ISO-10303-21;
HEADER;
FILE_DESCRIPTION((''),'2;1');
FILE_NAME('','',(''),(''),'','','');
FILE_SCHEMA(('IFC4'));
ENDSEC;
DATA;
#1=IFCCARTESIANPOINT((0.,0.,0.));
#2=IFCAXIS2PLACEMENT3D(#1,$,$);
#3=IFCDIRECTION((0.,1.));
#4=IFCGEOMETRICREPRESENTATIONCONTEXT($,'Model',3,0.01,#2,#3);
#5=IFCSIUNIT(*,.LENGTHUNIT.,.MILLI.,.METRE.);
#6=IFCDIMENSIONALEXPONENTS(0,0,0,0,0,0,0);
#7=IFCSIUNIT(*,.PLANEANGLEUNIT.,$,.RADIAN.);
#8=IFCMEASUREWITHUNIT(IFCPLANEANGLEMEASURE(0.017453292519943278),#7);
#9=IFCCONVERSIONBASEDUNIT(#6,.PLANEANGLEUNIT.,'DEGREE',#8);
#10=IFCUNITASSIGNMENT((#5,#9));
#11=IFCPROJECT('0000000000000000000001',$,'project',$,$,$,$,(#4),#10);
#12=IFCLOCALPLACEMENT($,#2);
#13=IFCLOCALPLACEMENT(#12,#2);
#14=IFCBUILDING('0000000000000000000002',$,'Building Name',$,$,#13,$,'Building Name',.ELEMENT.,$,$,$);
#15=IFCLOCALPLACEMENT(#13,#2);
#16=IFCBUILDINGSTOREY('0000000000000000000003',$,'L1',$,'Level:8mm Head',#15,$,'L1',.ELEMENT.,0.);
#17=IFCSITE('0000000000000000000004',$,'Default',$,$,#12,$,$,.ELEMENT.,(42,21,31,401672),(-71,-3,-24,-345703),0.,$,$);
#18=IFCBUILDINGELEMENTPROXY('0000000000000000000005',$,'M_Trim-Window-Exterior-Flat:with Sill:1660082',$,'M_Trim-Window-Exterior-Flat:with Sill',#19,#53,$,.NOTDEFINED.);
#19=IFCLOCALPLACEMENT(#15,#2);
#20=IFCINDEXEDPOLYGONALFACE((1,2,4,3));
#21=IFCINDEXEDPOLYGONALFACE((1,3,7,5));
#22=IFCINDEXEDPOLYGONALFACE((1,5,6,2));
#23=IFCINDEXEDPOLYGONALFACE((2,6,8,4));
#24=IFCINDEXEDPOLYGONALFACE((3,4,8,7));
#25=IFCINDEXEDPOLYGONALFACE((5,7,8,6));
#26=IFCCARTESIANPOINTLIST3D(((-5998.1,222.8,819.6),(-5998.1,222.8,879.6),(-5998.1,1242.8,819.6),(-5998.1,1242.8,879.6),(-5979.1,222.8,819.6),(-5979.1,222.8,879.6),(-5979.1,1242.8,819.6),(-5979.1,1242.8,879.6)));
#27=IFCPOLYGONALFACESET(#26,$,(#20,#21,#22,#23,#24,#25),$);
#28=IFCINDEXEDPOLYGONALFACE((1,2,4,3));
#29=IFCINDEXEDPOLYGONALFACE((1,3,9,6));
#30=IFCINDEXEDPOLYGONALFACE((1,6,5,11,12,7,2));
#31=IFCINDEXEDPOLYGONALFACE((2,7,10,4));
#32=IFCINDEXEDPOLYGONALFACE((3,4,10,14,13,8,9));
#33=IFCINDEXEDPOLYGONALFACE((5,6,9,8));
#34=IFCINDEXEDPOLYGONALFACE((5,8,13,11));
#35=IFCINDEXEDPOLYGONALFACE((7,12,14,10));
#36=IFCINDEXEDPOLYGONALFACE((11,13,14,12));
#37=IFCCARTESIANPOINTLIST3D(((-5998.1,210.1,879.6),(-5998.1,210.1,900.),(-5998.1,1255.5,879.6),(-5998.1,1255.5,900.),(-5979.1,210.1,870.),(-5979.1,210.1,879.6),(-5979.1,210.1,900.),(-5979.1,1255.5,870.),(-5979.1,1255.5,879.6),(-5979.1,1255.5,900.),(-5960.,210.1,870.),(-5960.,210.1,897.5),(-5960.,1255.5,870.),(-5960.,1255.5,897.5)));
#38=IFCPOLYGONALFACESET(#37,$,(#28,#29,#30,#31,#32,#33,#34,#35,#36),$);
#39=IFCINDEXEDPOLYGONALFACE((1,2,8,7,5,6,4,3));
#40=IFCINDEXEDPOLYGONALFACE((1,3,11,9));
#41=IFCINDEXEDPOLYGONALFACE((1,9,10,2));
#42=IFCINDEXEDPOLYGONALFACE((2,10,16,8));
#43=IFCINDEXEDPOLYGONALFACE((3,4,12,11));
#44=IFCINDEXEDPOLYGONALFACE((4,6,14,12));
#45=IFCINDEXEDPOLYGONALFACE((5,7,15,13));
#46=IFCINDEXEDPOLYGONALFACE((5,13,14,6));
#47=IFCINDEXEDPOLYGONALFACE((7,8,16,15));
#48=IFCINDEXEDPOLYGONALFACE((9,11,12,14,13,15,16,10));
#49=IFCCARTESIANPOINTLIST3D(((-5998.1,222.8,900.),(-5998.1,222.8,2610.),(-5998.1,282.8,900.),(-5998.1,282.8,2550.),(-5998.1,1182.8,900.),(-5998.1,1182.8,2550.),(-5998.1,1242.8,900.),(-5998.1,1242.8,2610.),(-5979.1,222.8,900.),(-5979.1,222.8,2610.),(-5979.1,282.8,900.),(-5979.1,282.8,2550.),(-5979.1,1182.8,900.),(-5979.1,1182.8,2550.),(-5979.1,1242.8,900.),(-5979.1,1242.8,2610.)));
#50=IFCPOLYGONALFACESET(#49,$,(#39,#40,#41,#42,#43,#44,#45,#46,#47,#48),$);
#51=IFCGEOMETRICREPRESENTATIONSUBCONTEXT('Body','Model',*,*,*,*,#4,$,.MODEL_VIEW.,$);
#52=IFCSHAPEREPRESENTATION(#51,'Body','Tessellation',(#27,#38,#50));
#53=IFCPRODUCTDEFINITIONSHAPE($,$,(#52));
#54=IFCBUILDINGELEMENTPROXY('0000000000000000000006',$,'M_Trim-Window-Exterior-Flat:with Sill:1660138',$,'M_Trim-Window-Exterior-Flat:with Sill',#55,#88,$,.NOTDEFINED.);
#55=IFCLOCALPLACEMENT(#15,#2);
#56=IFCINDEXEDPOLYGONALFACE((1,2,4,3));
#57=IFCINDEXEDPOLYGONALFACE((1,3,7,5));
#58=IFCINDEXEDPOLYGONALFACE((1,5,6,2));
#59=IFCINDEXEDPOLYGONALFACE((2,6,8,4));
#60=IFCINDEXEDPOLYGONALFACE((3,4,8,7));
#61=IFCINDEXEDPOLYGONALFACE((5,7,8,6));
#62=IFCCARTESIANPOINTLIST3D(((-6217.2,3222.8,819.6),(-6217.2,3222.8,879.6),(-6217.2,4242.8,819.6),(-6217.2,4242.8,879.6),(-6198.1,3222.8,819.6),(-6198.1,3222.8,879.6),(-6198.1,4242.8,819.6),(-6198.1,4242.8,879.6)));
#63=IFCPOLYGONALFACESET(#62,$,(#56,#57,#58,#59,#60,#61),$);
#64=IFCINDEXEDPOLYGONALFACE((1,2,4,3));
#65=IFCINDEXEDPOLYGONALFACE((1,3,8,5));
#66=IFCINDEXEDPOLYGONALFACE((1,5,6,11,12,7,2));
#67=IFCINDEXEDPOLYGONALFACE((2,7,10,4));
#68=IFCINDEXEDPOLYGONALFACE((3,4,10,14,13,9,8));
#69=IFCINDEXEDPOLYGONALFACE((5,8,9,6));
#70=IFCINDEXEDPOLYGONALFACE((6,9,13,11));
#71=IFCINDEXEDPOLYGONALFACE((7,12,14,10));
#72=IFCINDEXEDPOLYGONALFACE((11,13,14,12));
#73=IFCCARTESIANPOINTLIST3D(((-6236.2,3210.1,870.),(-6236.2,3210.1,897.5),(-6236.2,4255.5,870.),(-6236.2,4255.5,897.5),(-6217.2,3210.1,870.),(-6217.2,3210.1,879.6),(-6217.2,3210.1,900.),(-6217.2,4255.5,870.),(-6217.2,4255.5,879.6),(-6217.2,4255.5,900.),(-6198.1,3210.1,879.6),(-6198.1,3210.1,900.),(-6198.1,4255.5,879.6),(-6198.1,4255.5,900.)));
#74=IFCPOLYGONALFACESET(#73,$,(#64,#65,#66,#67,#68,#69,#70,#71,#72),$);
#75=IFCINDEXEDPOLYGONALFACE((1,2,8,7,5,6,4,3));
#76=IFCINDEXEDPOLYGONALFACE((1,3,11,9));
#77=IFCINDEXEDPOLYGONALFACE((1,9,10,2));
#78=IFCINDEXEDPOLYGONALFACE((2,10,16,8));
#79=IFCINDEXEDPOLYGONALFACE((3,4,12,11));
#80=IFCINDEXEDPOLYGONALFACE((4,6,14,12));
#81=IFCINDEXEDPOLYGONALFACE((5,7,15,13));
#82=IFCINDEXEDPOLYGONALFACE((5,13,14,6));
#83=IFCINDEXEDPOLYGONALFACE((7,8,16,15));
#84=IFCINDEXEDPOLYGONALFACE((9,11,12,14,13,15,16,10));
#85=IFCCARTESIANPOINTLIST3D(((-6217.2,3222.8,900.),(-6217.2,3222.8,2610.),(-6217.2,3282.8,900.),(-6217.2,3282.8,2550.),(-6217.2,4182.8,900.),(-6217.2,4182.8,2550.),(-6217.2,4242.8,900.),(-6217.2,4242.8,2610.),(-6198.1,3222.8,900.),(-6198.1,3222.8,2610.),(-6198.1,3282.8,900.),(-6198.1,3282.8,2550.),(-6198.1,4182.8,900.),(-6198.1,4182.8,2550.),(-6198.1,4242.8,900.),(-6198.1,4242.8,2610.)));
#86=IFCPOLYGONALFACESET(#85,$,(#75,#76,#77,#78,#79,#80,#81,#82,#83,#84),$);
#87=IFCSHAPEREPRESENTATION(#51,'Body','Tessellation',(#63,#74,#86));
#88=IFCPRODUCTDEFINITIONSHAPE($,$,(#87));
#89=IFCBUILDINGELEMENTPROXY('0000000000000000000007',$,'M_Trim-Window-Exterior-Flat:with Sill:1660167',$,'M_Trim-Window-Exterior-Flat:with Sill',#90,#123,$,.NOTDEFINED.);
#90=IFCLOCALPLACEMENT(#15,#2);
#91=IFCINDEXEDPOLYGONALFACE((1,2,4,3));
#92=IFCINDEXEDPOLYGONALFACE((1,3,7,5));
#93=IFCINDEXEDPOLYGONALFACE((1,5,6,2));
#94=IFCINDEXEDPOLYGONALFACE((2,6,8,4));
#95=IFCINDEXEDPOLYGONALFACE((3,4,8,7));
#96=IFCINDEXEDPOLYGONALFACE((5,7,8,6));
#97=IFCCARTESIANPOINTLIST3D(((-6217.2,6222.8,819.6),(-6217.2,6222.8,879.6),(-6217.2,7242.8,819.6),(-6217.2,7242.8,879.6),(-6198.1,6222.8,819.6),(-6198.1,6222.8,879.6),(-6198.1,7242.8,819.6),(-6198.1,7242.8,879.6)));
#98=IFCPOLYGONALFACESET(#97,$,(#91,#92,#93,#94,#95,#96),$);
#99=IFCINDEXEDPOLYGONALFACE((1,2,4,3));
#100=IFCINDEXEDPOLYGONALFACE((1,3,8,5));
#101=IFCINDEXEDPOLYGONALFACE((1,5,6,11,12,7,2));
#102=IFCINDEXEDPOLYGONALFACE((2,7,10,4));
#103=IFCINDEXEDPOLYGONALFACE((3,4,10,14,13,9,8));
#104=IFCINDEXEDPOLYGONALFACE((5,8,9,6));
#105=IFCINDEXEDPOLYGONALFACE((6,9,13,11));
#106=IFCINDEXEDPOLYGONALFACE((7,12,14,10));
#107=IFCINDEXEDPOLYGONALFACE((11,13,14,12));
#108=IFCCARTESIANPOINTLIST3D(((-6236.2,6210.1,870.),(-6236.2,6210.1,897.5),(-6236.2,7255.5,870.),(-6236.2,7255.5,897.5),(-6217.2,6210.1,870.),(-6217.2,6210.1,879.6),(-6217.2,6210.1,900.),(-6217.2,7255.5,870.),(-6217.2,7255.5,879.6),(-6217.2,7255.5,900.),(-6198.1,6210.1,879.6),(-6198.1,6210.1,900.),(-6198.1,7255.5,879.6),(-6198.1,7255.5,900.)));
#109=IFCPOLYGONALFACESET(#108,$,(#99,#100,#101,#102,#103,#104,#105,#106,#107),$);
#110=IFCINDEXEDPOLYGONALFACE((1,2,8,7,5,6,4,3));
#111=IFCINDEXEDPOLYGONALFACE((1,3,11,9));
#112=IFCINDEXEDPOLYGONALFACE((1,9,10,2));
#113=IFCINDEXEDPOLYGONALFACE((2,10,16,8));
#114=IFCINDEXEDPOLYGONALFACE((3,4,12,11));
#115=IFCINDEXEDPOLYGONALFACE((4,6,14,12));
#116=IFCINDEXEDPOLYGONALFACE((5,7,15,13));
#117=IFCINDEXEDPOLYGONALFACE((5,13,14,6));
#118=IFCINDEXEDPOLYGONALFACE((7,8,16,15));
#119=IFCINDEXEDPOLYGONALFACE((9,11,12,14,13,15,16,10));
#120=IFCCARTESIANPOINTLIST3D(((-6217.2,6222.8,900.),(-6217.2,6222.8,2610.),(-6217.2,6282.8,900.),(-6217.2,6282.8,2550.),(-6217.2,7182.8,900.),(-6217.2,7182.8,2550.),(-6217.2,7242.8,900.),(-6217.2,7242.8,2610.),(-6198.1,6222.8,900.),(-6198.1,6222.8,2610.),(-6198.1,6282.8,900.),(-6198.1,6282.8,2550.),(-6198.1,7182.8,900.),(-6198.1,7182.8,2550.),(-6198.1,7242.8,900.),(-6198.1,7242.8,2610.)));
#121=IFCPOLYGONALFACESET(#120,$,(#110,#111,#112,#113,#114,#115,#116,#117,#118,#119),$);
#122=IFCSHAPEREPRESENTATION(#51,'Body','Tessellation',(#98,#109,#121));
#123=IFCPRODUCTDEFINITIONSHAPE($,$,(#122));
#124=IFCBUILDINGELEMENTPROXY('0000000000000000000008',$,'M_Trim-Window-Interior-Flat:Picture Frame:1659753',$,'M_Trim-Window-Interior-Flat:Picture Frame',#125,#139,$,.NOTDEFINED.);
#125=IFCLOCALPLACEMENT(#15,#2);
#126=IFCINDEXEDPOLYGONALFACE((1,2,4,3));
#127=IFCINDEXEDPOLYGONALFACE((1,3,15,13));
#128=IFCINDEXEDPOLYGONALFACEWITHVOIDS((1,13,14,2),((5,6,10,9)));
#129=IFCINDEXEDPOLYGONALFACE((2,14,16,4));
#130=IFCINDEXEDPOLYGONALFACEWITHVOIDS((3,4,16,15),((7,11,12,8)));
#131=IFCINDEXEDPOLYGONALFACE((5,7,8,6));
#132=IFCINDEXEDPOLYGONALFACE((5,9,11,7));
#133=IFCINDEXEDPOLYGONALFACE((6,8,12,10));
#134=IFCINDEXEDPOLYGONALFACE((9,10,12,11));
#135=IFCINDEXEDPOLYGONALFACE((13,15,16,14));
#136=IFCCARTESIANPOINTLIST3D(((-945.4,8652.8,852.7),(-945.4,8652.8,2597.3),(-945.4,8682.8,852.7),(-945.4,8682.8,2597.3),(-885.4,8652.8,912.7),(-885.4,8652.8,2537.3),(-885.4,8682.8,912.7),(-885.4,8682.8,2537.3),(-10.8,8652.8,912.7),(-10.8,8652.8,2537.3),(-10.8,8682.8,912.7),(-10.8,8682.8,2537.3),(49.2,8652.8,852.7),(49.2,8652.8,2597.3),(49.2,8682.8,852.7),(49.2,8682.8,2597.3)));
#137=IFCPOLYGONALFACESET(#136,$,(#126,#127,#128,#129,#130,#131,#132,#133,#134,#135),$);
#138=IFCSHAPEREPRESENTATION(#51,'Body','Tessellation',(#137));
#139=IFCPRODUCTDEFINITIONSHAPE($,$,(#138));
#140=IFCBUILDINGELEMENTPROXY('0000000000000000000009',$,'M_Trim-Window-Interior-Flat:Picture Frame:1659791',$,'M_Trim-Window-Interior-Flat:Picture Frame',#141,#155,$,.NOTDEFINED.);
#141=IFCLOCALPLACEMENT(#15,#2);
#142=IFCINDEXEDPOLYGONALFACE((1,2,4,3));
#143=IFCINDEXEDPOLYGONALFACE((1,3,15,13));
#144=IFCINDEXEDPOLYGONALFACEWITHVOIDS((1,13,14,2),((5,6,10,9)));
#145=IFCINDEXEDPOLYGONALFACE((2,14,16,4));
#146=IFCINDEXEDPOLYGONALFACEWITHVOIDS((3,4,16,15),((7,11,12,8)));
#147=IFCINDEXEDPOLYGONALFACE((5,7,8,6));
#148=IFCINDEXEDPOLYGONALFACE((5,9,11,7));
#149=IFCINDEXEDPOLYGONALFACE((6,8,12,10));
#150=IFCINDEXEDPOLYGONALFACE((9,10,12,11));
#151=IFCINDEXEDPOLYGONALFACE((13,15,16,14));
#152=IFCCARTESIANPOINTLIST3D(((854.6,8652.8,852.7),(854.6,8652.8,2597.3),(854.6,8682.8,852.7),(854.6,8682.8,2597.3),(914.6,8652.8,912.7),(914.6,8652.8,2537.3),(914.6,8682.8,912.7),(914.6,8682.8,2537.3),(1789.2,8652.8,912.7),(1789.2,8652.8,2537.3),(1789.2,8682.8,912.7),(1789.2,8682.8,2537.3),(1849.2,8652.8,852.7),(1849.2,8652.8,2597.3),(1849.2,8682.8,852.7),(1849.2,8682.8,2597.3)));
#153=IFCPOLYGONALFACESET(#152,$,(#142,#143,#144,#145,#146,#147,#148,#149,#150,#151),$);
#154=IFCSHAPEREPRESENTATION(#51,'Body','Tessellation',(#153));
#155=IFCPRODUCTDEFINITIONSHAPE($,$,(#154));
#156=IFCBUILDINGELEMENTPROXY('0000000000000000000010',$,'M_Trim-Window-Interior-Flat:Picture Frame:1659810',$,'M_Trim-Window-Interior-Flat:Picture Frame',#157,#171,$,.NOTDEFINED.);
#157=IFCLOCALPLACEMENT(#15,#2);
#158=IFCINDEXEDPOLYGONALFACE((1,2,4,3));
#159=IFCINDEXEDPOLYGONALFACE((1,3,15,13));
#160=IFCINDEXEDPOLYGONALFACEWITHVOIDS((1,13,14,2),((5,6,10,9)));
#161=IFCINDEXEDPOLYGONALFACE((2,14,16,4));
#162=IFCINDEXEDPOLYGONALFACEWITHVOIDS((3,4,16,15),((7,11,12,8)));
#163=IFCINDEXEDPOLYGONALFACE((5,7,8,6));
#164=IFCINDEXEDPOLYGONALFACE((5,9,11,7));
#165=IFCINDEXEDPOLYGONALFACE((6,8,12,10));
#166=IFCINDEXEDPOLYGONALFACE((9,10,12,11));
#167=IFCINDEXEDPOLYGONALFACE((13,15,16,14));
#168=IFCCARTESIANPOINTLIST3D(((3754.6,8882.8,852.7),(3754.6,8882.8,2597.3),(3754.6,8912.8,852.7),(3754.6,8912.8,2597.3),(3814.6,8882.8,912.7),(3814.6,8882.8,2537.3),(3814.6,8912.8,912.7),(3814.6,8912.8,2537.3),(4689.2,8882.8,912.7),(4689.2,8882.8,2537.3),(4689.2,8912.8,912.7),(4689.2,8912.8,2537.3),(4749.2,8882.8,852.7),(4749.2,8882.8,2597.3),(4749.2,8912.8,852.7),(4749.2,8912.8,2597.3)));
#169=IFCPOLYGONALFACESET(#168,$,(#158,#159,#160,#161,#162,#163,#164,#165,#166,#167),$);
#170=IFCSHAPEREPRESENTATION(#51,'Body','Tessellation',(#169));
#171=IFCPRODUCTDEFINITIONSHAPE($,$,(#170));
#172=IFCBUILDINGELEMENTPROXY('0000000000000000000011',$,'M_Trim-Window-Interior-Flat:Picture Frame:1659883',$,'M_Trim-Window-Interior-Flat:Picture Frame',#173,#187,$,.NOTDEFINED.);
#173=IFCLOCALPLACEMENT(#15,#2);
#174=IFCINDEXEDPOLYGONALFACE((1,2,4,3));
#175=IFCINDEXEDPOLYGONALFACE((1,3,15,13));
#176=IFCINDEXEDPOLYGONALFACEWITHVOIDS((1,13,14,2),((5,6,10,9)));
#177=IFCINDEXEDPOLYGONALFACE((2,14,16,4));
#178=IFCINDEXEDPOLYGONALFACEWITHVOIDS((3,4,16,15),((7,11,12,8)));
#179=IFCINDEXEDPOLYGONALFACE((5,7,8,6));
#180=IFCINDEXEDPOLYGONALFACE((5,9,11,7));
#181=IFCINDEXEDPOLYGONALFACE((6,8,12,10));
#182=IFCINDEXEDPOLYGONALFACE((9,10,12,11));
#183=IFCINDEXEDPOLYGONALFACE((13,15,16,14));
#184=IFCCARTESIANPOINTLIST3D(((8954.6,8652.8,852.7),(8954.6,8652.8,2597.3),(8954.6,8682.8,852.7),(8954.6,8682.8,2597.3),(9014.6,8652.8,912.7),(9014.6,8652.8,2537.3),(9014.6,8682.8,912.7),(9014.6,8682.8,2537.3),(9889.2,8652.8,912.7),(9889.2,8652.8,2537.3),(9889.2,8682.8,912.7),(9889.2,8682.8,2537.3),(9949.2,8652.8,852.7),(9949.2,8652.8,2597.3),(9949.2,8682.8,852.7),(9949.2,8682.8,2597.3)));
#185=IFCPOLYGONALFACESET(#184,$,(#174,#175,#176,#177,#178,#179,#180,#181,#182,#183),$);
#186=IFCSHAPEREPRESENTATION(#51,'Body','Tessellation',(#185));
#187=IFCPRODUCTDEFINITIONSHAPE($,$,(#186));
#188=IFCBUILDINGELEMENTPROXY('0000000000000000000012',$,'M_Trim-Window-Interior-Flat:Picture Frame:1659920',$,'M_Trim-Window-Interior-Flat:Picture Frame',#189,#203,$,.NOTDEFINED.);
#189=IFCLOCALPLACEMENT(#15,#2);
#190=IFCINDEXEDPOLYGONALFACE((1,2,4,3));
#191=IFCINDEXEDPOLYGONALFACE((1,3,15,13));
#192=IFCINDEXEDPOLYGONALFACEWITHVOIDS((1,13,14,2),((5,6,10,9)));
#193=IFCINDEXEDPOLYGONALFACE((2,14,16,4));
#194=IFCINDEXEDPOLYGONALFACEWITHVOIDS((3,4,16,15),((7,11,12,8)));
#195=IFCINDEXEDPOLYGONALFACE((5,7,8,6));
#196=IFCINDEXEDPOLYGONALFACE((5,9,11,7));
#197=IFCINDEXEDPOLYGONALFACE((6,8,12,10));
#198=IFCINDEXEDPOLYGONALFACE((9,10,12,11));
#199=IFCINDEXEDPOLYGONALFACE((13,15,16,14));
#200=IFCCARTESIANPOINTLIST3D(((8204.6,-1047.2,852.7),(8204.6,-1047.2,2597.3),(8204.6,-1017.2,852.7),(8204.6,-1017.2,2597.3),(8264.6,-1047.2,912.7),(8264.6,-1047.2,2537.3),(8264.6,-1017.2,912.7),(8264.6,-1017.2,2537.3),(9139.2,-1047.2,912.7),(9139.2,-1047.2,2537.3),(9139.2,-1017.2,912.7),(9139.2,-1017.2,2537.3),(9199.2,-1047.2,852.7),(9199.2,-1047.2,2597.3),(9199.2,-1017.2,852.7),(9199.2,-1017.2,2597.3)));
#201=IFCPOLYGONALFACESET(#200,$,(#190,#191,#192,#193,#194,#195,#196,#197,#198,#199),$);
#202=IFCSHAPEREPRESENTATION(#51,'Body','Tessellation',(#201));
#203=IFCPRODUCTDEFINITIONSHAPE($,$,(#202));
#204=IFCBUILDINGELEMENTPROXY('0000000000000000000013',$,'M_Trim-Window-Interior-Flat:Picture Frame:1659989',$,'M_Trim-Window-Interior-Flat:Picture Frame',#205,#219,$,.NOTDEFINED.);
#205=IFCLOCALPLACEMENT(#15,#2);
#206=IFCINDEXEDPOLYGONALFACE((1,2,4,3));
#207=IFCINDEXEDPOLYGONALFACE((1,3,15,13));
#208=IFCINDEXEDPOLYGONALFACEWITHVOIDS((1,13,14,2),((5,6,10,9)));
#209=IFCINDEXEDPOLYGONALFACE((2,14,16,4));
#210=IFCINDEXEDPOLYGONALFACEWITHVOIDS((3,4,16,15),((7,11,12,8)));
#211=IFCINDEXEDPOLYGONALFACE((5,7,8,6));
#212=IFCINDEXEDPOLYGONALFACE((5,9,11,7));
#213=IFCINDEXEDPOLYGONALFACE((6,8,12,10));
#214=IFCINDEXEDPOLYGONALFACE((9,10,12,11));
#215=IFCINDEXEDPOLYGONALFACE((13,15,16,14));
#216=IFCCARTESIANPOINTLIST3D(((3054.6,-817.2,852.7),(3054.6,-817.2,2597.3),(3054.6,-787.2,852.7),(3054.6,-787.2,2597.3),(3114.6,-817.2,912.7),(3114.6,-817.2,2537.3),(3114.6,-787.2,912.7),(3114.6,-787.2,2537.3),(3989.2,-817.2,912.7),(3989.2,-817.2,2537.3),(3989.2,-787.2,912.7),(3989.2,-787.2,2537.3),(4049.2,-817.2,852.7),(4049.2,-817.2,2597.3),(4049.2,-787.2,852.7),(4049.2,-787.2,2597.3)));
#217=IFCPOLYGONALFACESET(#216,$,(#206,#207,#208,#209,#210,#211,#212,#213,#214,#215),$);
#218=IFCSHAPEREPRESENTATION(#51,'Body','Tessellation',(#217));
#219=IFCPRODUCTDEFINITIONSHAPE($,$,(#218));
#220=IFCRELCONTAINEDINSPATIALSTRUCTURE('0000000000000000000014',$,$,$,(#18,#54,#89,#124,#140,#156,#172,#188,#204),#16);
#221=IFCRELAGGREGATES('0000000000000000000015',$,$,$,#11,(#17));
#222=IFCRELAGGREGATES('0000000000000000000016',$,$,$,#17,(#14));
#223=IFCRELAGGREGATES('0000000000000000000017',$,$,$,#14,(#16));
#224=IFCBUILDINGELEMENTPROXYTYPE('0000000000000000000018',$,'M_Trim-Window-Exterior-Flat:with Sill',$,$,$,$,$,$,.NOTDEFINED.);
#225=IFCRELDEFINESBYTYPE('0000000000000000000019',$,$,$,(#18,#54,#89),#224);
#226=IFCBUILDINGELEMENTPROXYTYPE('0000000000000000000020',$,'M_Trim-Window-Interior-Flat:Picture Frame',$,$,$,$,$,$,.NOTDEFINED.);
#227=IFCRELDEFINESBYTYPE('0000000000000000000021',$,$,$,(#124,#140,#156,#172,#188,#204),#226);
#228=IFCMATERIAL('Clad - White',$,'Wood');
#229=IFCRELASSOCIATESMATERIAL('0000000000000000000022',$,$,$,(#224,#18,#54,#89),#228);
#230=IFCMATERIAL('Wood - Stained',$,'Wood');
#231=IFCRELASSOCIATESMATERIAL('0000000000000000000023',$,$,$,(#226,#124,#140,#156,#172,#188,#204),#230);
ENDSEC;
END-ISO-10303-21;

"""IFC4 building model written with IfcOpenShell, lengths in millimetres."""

from ifc_helpers import new_model, entity, si_unit, converted_unit, direction, frame, origin, place, context, subcontext, project, spatial, indexed_curve, outline, extrude, source, transform, mapped, material, type_object, type_shapes, element, save


model = new_model("IFC4")

# Units and contexts
model_context = context("Model", 3, precision=0.01, world=origin(), true_north=direction((0.0, 1.0)))
body_context = subcontext(model_context, "Body", "Model", "MODEL_VIEW")
ifc_project = project(units=[si_unit("LENGTHUNIT", "METRE", prefix="MILLI"), converted_unit("PLANEANGLEUNIT", "DEGREE", entity("IfcPlaneAngleMeasure", 0.017453292519943278), si_unit("PLANEANGLEUNIT", "RADIAN"), dimensions=[0, 0, 0, 0, 0, 0, 0])], contexts=[model_context])

# Site, building, storey
site_placement = place(None, origin())
site = spatial("IfcSite", under=ifc_project, at=site_placement, Name="Default", CompositionType="ELEMENT", RefLatitude=(42, 21, 31, 401672), RefLongitude=(-71, -3, -24, -345703), RefElevation=0.0)
building_placement = place(site_placement, origin())
building = spatial("IfcBuilding", under=site, at=building_placement, Name="Building Name", LongName="Building Name", CompositionType="ELEMENT")
storey_placement = place(building_placement, origin())
storey = spatial("IfcBuildingStorey", under=building, at=storey_placement, Name="L1", ObjectType="Level:8mm Head", LongName="L1", CompositionType="ELEMENT", Elevation=0.0)

# Building element proxies
ifc_material_1 = material(Name="Clad - White", Category="Wood")
ifc_material_2 = material(Name="Wood - Stained", Category="Wood")
building_element_proxy_type_1 = type_object("IfcBuildingElementProxyType", Name="M_Trim-Window-Exterior-Flat:with Sill", PredefinedType="NOTDEFINED", material=ifc_material_1)
shared_shape_1 = source(origin(), body_context, "Body", "SweptSolid", [
    extrude(outline(indexed_curve([(-510.0, -30.0), (510.0, -30.0), (510.0, 30.0), (-510.0, 30.0), (-510.0, -30.0)], self_intersect=False)), frame((0.0, -1700.4, 0.0), z_axis=(0.0, 0.0, 1.0), x_axis=(-1.0, 0.0, 0.0)), (0.0, 0.0, 1.0), 19.0),
    extrude(outline(indexed_curve([(-19.0, -15.2), (0.0, -15.2), (0.0, -5.7), (19.0, -5.7), (19.0, 14.8), (0.0, 14.8), (-19.0, 12.3), (-19.0, -15.2)], self_intersect=False)), frame((-522.7, -1664.8, 19.0), z_axis=(1.0, 0.0, 0.0), x_axis=(0.0, 0.0, -1.0)), (0.0, 0.0, 1.0), 1045.4),
    extrude(outline(indexed_curve([(-870.0, -510.0), (840.0, -510.0), (840.0, -450.0), (-810.0, -450.0), (-810.0, 450.0), (840.0, 450.0), (840.0, 510.0), (-870.0, 510.0), (-870.0, -510.0)], self_intersect=False)), frame((0.0, -810.0, 0.0), z_axis=(0.0, 0.0, 1.0), x_axis=(0.0, -1.0, 0.0)), (0.0, 0.0, 1.0), 19.0),
])
type_shapes(building_element_proxy_type_1, [shared_shape_1])
for number, where, z_axis, x_axis, name in (
    (1, (-5998.1, 732.8, 2550.0), (1.0, 0.0, 0.0), (0.0, 1.0, 0.0), "M_Trim-Window-Exterior-Flat:with Sill:1660082"),
    (2, (-6198.1, 3732.8, 2550.0), (-1.0, 0.0, 0.0), (0.0, -1.0, 0.0), "M_Trim-Window-Exterior-Flat:with Sill:1660138"),
    (3, (-6198.1, 6732.8, 2550.0), (-1.0, 0.0, 0.0), (0.0, -1.0, 0.0), "M_Trim-Window-Exterior-Flat:with Sill:1660167"),
):
    element("IfcBuildingElementProxy", number, at=place(storey_placement, frame(where, z_axis=z_axis, x_axis=x_axis)), inside=storey, type_object=building_element_proxy_type_1, material=ifc_material_1, Name=name, ObjectType="M_Trim-Window-Exterior-Flat:with Sill", PredefinedType="NOTDEFINED", context=body_context, shape_type="MappedRepresentation", body=[
        mapped(shared_shape_1, transform((0.0, 0.0, 0.0), scale=1.0)),
    ])
building_element_proxy_type_2 = type_object("IfcBuildingElementProxyType", Name="M_Trim-Window-Interior-Flat:Picture Frame", PredefinedType="NOTDEFINED", material=ifc_material_2)
shared_shape_2 = source(origin(), body_context, "Body", "SweptSolid", [
    extrude(outline(indexed_curve([(-497.3, -872.3), (497.3, -872.3), (497.3, 872.3), (-497.3, 872.3), (-497.3, -872.3)], self_intersect=False), holes=[indexed_curve([(-437.3, -812.3), (-437.3, 812.3), (437.3, 812.3), (437.3, -812.3), (-437.3, -812.3)], self_intersect=False)]), frame((0.0, -825.0, 0.0), z_axis=(0.0, 0.0, 1.0), x_axis=(-1.0, 0.0, 0.0)), (0.0, 0.0, 1.0), 30.0),
])
type_shapes(building_element_proxy_type_2, [shared_shape_2])
for number, where, z_axis, x_axis, name in (
    (4, (-448.1, 8682.8, 2550.0), (0.0, -1.0, 0.0), (1.0, 0.0, 0.0), "M_Trim-Window-Interior-Flat:Picture Frame:1659753"),
    (5, (1351.9, 8682.8, 2550.0), (0.0, -1.0, 0.0), (1.0, 0.0, 0.0), "M_Trim-Window-Interior-Flat:Picture Frame:1659791"),
    (6, (4251.9, 8882.8, 2550.0), (0.0, 1.0, 0.0), (-1.0, 0.0, 0.0), "M_Trim-Window-Interior-Flat:Picture Frame:1659810"),
    (7, (9451.9, 8682.8, 2550.0), (0.0, -1.0, 0.0), (1.0, 0.0, 0.0), "M_Trim-Window-Interior-Flat:Picture Frame:1659883"),
    (8, (8701.9, -1017.2, 2550.0), (0.0, -1.0, 0.0), (1.0, 0.0, 0.0), "M_Trim-Window-Interior-Flat:Picture Frame:1659920"),
    (9, (3551.9, -817.2, 2550.0), (0.0, 1.0, 0.0), (-1.0, 0.0, 0.0), "M_Trim-Window-Interior-Flat:Picture Frame:1659989"),
):
    element("IfcBuildingElementProxy", number, at=place(storey_placement, frame(where, z_axis=z_axis, x_axis=x_axis)), inside=storey, type_object=building_element_proxy_type_2, material=ifc_material_2, Name=name, ObjectType="M_Trim-Window-Interior-Flat:Picture Frame", PredefinedType="NOTDEFINED", context=body_context, shape_type="MappedRepresentation", body=[
        mapped(shared_shape_2, transform((0.0, 0.0, 0.0), scale=1.0)),
    ])

save(model, "model.ifc")
